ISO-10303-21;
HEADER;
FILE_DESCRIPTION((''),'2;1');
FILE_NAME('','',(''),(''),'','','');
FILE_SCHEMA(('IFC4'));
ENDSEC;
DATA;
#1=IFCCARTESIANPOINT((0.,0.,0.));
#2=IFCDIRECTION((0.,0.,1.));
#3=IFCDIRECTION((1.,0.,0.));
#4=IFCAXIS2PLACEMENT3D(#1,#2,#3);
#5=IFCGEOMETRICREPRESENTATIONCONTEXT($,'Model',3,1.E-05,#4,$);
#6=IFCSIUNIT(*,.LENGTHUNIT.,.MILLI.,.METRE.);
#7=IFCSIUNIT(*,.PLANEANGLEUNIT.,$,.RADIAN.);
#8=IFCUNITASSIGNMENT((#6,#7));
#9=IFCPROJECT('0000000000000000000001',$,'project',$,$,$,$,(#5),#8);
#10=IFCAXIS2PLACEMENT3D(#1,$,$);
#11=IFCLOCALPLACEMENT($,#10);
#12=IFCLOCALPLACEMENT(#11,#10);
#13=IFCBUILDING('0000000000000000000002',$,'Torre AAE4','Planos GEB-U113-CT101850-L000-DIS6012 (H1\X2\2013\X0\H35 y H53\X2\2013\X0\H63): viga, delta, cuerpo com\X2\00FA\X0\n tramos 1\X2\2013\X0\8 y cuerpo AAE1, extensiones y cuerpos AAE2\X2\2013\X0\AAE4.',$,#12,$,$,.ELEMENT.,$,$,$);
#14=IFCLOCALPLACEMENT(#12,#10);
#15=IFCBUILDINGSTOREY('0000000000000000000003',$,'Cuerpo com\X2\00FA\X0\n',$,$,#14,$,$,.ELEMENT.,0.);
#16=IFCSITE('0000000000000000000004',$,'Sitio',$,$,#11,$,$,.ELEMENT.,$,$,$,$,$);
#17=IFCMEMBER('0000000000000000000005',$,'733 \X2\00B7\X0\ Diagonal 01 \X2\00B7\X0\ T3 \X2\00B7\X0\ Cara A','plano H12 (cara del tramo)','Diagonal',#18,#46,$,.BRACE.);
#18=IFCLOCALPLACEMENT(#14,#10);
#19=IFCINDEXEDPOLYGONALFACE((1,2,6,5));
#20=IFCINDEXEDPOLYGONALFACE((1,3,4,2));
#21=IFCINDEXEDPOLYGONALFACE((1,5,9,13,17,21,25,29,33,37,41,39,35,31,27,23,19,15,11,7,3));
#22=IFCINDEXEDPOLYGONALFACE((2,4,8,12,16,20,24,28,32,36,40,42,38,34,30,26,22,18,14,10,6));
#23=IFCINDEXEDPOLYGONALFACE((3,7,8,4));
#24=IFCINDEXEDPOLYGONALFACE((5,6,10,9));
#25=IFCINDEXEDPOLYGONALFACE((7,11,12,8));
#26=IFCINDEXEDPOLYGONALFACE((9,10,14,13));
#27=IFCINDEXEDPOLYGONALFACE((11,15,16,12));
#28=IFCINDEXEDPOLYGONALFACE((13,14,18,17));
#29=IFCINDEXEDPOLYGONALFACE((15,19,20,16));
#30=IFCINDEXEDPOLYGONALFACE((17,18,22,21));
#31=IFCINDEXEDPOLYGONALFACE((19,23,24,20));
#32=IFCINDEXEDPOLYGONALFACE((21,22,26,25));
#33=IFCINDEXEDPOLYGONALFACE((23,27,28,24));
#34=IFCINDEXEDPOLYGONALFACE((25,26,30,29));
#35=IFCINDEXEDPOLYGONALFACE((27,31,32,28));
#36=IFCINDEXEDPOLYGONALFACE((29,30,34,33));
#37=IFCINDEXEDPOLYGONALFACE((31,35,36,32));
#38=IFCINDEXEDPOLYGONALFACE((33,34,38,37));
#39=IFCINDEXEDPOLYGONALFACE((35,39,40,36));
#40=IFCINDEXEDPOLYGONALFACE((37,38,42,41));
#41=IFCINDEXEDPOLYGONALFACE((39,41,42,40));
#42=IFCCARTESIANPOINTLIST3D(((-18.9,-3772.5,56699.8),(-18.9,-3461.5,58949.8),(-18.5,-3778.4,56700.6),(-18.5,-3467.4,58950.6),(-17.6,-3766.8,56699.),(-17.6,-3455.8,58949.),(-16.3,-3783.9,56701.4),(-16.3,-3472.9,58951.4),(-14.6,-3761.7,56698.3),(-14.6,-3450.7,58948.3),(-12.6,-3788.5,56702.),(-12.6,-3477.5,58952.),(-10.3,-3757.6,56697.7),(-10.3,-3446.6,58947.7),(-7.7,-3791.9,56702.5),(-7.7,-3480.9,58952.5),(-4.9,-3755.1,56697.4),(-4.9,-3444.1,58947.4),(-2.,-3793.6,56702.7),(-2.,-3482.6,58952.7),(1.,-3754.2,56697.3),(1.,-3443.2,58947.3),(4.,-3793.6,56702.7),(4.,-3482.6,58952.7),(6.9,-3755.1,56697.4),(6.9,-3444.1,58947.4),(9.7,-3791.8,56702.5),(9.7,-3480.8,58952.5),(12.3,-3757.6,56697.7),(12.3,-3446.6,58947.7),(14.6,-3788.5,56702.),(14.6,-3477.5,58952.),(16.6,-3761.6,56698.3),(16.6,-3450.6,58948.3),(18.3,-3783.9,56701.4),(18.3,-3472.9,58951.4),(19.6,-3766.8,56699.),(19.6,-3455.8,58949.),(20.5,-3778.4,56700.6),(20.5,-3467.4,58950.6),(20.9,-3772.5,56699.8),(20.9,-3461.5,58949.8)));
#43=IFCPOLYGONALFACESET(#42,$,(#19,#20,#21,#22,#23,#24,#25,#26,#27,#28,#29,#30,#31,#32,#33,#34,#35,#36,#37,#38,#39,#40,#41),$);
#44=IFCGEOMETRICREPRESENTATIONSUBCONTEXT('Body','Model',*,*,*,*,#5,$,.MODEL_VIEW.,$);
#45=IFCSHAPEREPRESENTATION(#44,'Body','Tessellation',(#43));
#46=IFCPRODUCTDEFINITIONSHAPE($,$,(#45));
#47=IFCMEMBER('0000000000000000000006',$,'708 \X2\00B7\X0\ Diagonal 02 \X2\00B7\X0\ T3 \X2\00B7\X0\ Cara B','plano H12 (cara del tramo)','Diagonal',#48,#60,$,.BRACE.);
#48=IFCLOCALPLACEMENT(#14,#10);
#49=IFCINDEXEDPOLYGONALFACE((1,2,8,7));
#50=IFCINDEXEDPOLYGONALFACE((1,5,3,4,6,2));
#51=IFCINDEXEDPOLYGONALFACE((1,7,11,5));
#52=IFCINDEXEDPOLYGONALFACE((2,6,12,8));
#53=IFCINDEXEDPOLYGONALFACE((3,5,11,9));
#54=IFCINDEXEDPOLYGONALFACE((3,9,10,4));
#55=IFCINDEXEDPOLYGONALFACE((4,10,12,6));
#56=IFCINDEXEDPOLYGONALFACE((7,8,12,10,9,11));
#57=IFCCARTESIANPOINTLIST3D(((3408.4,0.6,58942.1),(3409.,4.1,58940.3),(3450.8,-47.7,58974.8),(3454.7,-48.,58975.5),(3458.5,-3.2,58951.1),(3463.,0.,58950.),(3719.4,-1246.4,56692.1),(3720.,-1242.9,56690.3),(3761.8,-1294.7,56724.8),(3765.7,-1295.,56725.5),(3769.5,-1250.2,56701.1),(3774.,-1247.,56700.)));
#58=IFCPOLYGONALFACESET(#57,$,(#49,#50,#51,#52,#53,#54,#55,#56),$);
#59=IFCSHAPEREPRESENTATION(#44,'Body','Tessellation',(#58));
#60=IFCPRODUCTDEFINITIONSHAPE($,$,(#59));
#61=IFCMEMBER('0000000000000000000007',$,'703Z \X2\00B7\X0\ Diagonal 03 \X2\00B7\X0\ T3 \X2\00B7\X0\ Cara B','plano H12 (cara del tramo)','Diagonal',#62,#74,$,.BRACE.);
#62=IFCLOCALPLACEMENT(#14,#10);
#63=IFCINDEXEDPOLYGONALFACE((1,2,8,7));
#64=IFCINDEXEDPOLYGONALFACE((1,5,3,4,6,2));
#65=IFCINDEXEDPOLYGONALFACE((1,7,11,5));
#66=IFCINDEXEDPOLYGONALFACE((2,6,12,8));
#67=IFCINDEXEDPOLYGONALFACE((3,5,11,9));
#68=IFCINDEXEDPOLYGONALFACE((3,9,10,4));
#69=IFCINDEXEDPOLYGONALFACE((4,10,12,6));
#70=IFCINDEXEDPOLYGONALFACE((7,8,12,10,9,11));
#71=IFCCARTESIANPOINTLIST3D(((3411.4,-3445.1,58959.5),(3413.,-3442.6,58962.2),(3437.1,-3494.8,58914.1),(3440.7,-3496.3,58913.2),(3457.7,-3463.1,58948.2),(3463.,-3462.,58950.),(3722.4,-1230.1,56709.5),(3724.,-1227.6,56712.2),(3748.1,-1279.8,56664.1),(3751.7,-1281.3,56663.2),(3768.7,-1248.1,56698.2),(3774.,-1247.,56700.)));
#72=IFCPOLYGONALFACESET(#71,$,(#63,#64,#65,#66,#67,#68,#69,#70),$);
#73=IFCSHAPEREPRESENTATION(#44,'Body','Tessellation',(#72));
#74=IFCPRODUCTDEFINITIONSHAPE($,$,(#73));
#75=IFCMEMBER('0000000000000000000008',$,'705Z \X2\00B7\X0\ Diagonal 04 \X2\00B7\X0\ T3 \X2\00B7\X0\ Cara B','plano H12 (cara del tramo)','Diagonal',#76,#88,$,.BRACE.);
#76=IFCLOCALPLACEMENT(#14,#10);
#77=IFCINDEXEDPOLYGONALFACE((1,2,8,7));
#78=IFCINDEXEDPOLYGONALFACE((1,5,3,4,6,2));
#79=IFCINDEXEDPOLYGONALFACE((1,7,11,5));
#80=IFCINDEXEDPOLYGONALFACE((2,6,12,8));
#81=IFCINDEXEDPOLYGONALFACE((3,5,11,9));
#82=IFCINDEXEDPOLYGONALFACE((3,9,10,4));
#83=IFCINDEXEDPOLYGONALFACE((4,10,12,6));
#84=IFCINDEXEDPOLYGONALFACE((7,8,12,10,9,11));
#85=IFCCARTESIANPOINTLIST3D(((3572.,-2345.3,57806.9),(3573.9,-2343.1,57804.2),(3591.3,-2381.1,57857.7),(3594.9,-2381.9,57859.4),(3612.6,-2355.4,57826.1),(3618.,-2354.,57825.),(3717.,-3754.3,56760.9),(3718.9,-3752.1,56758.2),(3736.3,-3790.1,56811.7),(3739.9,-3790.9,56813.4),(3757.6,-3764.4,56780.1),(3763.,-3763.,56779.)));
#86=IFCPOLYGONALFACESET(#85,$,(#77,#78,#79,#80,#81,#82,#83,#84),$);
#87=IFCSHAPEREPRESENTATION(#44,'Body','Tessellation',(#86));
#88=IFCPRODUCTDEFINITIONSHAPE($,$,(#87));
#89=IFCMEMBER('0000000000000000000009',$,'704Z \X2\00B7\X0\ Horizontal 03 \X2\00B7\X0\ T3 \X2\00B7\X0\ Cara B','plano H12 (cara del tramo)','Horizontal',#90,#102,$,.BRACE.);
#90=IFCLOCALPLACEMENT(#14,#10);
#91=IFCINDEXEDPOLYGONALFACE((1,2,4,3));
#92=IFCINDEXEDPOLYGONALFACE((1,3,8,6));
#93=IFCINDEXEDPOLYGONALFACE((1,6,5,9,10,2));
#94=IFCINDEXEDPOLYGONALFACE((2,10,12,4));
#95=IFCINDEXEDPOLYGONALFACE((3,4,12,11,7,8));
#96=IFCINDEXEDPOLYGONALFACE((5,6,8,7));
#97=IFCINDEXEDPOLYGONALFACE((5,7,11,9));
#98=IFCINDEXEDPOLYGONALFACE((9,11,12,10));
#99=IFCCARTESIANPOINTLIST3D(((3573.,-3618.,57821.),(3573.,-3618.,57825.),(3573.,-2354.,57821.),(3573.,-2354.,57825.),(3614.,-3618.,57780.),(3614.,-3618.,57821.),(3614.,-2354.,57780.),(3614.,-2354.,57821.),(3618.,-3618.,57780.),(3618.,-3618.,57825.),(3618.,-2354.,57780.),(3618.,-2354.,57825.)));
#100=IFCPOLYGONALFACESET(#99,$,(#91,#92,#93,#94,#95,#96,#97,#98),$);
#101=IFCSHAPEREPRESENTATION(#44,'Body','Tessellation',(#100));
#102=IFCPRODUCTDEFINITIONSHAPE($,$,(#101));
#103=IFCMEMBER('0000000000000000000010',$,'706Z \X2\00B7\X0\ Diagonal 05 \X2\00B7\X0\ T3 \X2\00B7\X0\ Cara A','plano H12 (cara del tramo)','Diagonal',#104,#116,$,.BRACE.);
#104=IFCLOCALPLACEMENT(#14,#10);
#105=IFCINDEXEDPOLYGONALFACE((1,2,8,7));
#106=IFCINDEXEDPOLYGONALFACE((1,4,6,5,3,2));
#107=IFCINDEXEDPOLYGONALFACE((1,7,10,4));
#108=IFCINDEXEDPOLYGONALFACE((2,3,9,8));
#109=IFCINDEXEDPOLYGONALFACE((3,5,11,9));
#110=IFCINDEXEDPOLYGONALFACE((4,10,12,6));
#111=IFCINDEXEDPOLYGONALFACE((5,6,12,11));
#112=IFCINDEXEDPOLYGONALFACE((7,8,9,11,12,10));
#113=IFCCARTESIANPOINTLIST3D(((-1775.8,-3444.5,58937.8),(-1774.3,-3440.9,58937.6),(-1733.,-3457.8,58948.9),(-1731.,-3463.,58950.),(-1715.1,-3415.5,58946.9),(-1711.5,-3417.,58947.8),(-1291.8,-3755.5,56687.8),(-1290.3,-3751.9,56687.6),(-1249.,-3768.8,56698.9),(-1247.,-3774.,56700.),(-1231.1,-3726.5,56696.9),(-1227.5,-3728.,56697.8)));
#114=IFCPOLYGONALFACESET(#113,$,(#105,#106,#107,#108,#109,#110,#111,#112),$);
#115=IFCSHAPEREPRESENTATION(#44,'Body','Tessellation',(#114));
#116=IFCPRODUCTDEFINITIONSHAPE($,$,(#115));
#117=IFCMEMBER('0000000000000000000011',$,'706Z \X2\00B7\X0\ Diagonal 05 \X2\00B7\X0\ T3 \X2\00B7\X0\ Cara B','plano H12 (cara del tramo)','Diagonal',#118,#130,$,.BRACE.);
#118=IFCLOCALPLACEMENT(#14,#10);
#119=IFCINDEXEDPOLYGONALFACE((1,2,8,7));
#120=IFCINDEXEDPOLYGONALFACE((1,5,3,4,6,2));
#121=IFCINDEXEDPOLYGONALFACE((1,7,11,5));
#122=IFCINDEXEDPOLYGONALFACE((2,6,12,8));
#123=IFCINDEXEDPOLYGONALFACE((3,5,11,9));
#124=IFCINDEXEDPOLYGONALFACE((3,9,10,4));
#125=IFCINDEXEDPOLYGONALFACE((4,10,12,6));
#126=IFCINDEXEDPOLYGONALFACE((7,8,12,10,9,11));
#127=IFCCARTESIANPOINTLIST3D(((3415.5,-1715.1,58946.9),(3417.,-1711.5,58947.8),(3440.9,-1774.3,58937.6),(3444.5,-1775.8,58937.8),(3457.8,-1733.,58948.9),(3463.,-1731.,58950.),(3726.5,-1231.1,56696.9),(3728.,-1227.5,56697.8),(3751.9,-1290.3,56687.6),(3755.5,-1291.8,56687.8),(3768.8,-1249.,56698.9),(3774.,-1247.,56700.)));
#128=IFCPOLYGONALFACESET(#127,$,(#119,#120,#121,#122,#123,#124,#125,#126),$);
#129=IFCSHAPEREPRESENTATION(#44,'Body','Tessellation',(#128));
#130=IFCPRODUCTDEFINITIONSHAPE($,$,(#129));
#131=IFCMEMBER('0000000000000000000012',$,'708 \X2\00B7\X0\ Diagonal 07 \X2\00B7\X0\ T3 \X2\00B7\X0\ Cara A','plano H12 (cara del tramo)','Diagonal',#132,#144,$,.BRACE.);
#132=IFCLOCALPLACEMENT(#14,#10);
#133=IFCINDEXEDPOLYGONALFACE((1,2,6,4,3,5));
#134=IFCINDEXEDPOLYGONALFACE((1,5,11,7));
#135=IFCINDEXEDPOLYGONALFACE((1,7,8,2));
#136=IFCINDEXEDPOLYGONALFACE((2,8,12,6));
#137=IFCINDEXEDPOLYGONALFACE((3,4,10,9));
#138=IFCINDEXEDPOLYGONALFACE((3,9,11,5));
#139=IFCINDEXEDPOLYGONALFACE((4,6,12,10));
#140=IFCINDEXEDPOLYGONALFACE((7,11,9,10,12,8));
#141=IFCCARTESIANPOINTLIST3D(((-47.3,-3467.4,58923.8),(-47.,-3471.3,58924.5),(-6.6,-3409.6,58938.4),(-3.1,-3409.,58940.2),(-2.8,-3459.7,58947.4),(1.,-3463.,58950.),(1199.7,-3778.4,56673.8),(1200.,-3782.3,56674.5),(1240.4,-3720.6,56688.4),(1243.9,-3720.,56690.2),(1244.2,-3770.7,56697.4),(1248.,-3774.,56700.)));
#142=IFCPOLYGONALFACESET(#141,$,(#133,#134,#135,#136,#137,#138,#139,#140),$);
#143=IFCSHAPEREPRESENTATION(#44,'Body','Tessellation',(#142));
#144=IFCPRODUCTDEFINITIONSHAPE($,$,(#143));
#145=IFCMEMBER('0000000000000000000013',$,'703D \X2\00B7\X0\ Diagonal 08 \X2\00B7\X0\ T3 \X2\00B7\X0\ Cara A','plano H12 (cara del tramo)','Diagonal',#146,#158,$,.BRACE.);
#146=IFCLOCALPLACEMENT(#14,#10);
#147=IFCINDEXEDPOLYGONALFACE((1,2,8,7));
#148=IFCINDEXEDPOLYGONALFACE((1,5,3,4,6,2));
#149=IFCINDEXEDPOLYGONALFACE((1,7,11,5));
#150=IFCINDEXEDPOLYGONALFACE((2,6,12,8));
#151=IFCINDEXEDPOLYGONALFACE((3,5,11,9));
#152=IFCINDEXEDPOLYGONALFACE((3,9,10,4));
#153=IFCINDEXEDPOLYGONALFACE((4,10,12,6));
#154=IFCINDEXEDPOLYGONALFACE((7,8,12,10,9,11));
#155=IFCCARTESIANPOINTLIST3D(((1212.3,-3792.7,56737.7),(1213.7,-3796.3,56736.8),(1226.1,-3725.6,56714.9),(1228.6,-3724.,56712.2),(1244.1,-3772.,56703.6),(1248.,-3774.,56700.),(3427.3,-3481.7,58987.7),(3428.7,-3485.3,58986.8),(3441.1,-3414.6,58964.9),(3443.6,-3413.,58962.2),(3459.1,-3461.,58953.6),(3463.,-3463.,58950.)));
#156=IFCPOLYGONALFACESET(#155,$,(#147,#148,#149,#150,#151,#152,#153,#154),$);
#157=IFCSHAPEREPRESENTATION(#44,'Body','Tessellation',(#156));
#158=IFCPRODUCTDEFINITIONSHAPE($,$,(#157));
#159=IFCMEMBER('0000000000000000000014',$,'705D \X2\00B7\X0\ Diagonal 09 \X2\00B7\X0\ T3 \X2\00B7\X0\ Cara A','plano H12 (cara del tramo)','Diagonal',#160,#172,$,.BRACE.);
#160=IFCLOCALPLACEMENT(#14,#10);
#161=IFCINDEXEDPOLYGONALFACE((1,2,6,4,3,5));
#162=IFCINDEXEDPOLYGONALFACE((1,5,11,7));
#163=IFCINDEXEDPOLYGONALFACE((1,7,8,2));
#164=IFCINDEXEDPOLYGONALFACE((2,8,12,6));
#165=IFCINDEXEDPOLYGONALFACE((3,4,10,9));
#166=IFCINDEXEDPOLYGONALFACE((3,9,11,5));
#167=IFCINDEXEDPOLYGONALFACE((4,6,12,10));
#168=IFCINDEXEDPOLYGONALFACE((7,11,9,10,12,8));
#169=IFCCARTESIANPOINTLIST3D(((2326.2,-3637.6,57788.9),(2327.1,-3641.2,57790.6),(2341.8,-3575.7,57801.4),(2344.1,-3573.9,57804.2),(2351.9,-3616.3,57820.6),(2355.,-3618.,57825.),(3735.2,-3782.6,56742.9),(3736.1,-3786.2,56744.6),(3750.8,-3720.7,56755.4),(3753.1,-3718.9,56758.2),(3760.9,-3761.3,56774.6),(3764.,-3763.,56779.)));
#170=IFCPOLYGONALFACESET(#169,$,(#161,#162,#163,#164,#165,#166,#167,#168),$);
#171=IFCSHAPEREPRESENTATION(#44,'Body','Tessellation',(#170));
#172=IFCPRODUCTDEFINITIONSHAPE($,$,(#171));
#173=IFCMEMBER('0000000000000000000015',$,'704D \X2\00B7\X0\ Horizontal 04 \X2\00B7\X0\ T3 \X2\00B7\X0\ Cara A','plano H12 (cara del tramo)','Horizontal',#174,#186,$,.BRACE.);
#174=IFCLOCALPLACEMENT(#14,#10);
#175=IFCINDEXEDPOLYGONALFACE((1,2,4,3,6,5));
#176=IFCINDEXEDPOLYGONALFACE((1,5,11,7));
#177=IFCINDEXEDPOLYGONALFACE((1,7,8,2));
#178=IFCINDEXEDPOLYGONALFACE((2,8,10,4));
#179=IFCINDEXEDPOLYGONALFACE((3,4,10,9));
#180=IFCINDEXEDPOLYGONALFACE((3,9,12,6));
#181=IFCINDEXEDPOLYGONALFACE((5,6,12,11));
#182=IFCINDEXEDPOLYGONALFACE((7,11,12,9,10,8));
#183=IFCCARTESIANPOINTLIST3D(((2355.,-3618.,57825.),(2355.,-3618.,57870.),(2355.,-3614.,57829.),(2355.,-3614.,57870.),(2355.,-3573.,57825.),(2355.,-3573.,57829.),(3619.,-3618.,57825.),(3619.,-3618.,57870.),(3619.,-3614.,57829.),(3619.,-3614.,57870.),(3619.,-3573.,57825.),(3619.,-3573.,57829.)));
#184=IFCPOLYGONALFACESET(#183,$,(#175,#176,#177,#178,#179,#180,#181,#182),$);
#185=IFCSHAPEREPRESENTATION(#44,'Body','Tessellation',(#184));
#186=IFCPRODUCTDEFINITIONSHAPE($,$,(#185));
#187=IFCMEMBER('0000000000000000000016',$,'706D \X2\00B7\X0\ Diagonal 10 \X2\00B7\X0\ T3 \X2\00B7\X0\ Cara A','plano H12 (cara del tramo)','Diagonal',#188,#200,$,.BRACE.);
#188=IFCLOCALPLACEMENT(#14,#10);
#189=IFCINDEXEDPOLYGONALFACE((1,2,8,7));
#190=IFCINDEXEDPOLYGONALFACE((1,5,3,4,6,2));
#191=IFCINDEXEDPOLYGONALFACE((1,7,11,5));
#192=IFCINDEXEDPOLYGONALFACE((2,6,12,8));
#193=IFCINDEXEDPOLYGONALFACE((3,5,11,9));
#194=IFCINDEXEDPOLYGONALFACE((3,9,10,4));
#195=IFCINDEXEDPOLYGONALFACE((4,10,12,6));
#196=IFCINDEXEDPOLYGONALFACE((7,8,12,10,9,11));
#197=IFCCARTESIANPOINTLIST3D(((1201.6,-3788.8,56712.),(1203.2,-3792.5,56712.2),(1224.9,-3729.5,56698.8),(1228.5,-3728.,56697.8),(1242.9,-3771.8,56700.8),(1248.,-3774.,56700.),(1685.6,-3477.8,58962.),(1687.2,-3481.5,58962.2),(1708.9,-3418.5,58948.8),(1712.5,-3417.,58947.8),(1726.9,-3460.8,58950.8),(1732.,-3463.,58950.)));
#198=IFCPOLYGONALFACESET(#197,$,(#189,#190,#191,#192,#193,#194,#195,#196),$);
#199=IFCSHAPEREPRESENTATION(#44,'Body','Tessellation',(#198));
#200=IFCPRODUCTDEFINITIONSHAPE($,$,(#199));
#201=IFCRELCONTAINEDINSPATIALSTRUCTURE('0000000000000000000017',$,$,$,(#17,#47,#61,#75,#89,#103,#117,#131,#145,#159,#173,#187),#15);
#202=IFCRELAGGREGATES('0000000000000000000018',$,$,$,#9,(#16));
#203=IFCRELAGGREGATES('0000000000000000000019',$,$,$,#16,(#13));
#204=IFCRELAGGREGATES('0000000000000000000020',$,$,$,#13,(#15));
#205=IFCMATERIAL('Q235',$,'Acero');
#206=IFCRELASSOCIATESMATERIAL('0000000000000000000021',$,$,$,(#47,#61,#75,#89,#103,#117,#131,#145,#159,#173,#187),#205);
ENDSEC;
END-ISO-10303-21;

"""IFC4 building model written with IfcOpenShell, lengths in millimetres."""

from ifc_helpers import new_model, si_unit, frame, frame_2d, origin, origin_with_axes, place, context, subcontext, project, spatial, circle, l_section, extrude, material, element, save


model = new_model("IFC4")

# Units and contexts
model_context = context("Model", 3, precision=1e-05, world=origin_with_axes())
body_context = subcontext(model_context, "Body", "Model", "MODEL_VIEW")
ifc_project = project(units=[si_unit("LENGTHUNIT", "METRE", prefix="MILLI"), si_unit("PLANEANGLEUNIT", "RADIAN")], contexts=[model_context])

# Site, building, storey
site_placement = place(None, origin())
site = spatial("IfcSite", under=ifc_project, at=site_placement, Name="Sitio", CompositionType="ELEMENT")
building_placement = place(site_placement, origin())
building = spatial("IfcBuilding", under=site, at=building_placement, Name="Torre AAE4", Description="Planos GEB-U113-CT101850-L000-DIS6012 (H1–H35 y H53–H63): viga, delta, cuerpo común tramos 1–8 y cuerpo AAE1, extensiones y cuerpos AAE2–AAE4.", CompositionType="ELEMENT")
storey_placement = place(building_placement, origin())
storey = spatial("IfcBuildingStorey", under=building, at=storey_placement, Name="Cuerpo común", CompositionType="ELEMENT", Elevation=0.0)

# Members
member_1_placement = place(storey_placement, frame((1.0, -3774.0, 56700.0), z_axis=(0.0, 0.13692, 0.990582), x_axis=(-0.000279, 0.990582, -0.13692)))
element("IfcMember", 1, at=member_1_placement, inside=storey, Name="733 · Diagonal 01 · T3 · Cara A", Description="plano H12 (cara del tramo)", ObjectType="Diagonal", PredefinedType="BRACE", context=body_context, shape_type="SweptSolid", body=[
    extrude(circle(Radius=20.0), None, (0.0, 0.0, 1.0), 2271.4),
])
ifc_material_1 = material(Name="Q235", Category="Acero")
member_2_placement = place(storey_placement, frame((3774.0, -1247.0, 56700.0), z_axis=(-0.120022, 0.481247, 0.868329), x_axis=(-0.981299, 0.075075, -0.177245)))
element("IfcMember", 2, at=member_2_placement, inside=storey, material=ifc_material_1, Name="708 · Diagonal 02 · T3 · Cara B", Description="plano H12 (cara del tramo)", ObjectType="Diagonal", PredefinedType="BRACE", context=body_context, shape_type="SweptSolid", body=[
    extrude(l_section(Depth=55.0, Width=55.0, Thickness=4.0, at=frame_2d((27.5, 27.5))), None, (0.0, 0.0, 1.0), 2591.2),
])
member_3_placement = place(storey_placement, frame((3774.0, -1247.0, 56700.0), z_axis=(-0.098027, -0.698164, 0.709196), x_axis=(-0.908922, 0.35302, 0.221895)))
element("IfcMember", 3, at=member_3_placement, inside=storey, material=ifc_material_1, Name="703Z · Diagonal 03 · T3 · Cara B", Description="plano H12 (cara del tramo)", ObjectType="Diagonal", PredefinedType="BRACE", context=body_context, shape_type="SweptSolid", body=[
    extrude(l_section(Depth=55.0, Width=55.0, Thickness=4.0, at=frame_2d((27.5, 27.5))), None, (0.0, 0.0, 1.0), 3172.6),
])
member_4_placement = place(storey_placement, frame((3763.0, -3763.0, 56779.0), z_axis=(-0.082349, 0.800204, 0.594048), x_axis=(-0.882566, 0.218321, -0.41643)))
element("IfcMember", 4, at=member_4_placement, inside=storey, material=ifc_material_1, Name="705Z · Diagonal 04 · T3 · Cara B", Description="plano H12 (cara del tramo)", ObjectType="Diagonal", PredefinedType="BRACE", context=body_context, shape_type="SweptSolid", body=[
    extrude(l_section(Depth=50.0, Width=50.0, Thickness=4.0, at=frame_2d((25.0, 25.0))), None, (0.0, 0.0, 1.0), 1760.8),
])
member_5_placement = place(storey_placement, frame((3618.0, -2354.0, 57825.0), z_axis=(0.0, -1.0, 0.0), x_axis=(-1.0, 0.0, 0.0)))
element("IfcMember", 5, at=member_5_placement, inside=storey, material=ifc_material_1, Name="704Z · Horizontal 03 · T3 · Cara B", Description="plano H12 (cara del tramo)", ObjectType="Horizontal", PredefinedType="BRACE", context=body_context, shape_type="SweptSolid", body=[
    extrude(l_section(Depth=45.0, Width=45.0, Thickness=4.0, at=frame_2d((22.5, 22.5))), None, (0.0, 0.0, 1.0), 1264.0),
])
for number, where, z_axis, x_axis, name in (
    (6, (-1247.0, -3774.0, 56700.0), (-0.208406, 0.133914, 0.968831), (0.390206, 0.919714, -0.043187), "706Z · Diagonal 05 · T3 · Cara A"),
    (7, (3774.0, -1247.0, 56700.0), (-0.133914, -0.208406, 0.968831), (-0.919714, 0.390206, -0.043187), "706Z · Diagonal 05 · T3 · Cara B"),
):
    element("IfcMember", number, at=place(storey_placement, frame(where, z_axis=z_axis, x_axis=x_axis)), inside=storey, material=ifc_material_1, Name=name, Description="plano H12 (cara del tramo)", ObjectType="Diagonal", PredefinedType="BRACE", context=body_context, shape_type="SweptSolid", body=[
        extrude(l_section(Depth=50.0, Width=50.0, Thickness=4.0, at=frame_2d((25.0, 25.0))), None, (0.0, 0.0, 1.0), 2322.4),
    ])
member_6_placement = place(storey_placement, frame((1248.0, -3774.0, 56700.0), z_axis=(-0.481247, 0.120022, 0.868329), x_axis=(-0.075287, 0.981263, -0.177358)))
element("IfcMember", 8, at=member_6_placement, inside=storey, material=ifc_material_1, Name="708 · Diagonal 07 · T3 · Cara A", Description="plano H12 (cara del tramo)", ObjectType="Diagonal", PredefinedType="BRACE", context=body_context, shape_type="SweptSolid", body=[
    extrude(l_section(Depth=55.0, Width=55.0, Thickness=4.0, at=frame_2d((27.5, 27.5))), None, (0.0, 0.0, 1.0), 2591.2),
])
member_7_placement = place(storey_placement, frame((1248.0, -3774.0, 56700.0), z_axis=(0.698164, 0.098027, 0.709196), x_axis=(-0.353114, 0.908861, 0.221997)))
element("IfcMember", 9, at=member_7_placement, inside=storey, material=ifc_material_1, Name="703D · Diagonal 08 · T3 · Cara A", Description="plano H12 (cara del tramo)", ObjectType="Diagonal", PredefinedType="BRACE", context=body_context, shape_type="SweptSolid", body=[
    extrude(l_section(Depth=55.0, Width=55.0, Thickness=4.0, at=frame_2d((27.5, 27.5))), None, (0.0, 0.0, 1.0), 3172.6),
])
member_8_placement = place(storey_placement, frame((3764.0, -3763.0, 56779.0), z_axis=(-0.800204, 0.082349, 0.594048), x_axis=(-0.2184, 0.8825, -0.416528)))
element("IfcMember", 10, at=member_8_placement, inside=storey, material=ifc_material_1, Name="705D · Diagonal 09 · T3 · Cara A", Description="plano H12 (cara del tramo)", ObjectType="Diagonal", PredefinedType="BRACE", context=body_context, shape_type="SweptSolid", body=[
    extrude(l_section(Depth=50.0, Width=50.0, Thickness=4.0, at=frame_2d((25.0, 25.0))), None, (0.0, 0.0, 1.0), 1760.8),
])
member_9_placement = place(storey_placement, frame((2355.0, -3618.0, 57825.0), z_axis=(1.0, 0.0, 0.0), x_axis=(0.0, 1.0, 0.0)))
element("IfcMember", 11, at=member_9_placement, inside=storey, material=ifc_material_1, Name="704D · Horizontal 04 · T3 · Cara A", Description="plano H12 (cara del tramo)", ObjectType="Horizontal", PredefinedType="BRACE", context=body_context, shape_type="SweptSolid", body=[
    extrude(l_section(Depth=45.0, Width=45.0, Thickness=4.0, at=frame_2d((22.5, 22.5))), None, (0.0, 0.0, 1.0), 1264.0),
])
member_10_placement = place(storey_placement, frame((1248.0, -3774.0, 56700.0), z_axis=(0.208406, 0.133914, 0.968831), x_axis=(-0.390411, 0.91963, -0.043131)))
element("IfcMember", 12, at=member_10_placement, inside=storey, material=ifc_material_1, Name="706D · Diagonal 10 · T3 · Cara A", Description="plano H12 (cara del tramo)", ObjectType="Diagonal", PredefinedType="BRACE", context=body_context, shape_type="SweptSolid", body=[
    extrude(l_section(Depth=50.0, Width=50.0, Thickness=4.0, at=frame_2d((25.0, 25.0))), None, (0.0, 0.0, 1.0), 2322.4),
])

save(model, "model.ifc")
